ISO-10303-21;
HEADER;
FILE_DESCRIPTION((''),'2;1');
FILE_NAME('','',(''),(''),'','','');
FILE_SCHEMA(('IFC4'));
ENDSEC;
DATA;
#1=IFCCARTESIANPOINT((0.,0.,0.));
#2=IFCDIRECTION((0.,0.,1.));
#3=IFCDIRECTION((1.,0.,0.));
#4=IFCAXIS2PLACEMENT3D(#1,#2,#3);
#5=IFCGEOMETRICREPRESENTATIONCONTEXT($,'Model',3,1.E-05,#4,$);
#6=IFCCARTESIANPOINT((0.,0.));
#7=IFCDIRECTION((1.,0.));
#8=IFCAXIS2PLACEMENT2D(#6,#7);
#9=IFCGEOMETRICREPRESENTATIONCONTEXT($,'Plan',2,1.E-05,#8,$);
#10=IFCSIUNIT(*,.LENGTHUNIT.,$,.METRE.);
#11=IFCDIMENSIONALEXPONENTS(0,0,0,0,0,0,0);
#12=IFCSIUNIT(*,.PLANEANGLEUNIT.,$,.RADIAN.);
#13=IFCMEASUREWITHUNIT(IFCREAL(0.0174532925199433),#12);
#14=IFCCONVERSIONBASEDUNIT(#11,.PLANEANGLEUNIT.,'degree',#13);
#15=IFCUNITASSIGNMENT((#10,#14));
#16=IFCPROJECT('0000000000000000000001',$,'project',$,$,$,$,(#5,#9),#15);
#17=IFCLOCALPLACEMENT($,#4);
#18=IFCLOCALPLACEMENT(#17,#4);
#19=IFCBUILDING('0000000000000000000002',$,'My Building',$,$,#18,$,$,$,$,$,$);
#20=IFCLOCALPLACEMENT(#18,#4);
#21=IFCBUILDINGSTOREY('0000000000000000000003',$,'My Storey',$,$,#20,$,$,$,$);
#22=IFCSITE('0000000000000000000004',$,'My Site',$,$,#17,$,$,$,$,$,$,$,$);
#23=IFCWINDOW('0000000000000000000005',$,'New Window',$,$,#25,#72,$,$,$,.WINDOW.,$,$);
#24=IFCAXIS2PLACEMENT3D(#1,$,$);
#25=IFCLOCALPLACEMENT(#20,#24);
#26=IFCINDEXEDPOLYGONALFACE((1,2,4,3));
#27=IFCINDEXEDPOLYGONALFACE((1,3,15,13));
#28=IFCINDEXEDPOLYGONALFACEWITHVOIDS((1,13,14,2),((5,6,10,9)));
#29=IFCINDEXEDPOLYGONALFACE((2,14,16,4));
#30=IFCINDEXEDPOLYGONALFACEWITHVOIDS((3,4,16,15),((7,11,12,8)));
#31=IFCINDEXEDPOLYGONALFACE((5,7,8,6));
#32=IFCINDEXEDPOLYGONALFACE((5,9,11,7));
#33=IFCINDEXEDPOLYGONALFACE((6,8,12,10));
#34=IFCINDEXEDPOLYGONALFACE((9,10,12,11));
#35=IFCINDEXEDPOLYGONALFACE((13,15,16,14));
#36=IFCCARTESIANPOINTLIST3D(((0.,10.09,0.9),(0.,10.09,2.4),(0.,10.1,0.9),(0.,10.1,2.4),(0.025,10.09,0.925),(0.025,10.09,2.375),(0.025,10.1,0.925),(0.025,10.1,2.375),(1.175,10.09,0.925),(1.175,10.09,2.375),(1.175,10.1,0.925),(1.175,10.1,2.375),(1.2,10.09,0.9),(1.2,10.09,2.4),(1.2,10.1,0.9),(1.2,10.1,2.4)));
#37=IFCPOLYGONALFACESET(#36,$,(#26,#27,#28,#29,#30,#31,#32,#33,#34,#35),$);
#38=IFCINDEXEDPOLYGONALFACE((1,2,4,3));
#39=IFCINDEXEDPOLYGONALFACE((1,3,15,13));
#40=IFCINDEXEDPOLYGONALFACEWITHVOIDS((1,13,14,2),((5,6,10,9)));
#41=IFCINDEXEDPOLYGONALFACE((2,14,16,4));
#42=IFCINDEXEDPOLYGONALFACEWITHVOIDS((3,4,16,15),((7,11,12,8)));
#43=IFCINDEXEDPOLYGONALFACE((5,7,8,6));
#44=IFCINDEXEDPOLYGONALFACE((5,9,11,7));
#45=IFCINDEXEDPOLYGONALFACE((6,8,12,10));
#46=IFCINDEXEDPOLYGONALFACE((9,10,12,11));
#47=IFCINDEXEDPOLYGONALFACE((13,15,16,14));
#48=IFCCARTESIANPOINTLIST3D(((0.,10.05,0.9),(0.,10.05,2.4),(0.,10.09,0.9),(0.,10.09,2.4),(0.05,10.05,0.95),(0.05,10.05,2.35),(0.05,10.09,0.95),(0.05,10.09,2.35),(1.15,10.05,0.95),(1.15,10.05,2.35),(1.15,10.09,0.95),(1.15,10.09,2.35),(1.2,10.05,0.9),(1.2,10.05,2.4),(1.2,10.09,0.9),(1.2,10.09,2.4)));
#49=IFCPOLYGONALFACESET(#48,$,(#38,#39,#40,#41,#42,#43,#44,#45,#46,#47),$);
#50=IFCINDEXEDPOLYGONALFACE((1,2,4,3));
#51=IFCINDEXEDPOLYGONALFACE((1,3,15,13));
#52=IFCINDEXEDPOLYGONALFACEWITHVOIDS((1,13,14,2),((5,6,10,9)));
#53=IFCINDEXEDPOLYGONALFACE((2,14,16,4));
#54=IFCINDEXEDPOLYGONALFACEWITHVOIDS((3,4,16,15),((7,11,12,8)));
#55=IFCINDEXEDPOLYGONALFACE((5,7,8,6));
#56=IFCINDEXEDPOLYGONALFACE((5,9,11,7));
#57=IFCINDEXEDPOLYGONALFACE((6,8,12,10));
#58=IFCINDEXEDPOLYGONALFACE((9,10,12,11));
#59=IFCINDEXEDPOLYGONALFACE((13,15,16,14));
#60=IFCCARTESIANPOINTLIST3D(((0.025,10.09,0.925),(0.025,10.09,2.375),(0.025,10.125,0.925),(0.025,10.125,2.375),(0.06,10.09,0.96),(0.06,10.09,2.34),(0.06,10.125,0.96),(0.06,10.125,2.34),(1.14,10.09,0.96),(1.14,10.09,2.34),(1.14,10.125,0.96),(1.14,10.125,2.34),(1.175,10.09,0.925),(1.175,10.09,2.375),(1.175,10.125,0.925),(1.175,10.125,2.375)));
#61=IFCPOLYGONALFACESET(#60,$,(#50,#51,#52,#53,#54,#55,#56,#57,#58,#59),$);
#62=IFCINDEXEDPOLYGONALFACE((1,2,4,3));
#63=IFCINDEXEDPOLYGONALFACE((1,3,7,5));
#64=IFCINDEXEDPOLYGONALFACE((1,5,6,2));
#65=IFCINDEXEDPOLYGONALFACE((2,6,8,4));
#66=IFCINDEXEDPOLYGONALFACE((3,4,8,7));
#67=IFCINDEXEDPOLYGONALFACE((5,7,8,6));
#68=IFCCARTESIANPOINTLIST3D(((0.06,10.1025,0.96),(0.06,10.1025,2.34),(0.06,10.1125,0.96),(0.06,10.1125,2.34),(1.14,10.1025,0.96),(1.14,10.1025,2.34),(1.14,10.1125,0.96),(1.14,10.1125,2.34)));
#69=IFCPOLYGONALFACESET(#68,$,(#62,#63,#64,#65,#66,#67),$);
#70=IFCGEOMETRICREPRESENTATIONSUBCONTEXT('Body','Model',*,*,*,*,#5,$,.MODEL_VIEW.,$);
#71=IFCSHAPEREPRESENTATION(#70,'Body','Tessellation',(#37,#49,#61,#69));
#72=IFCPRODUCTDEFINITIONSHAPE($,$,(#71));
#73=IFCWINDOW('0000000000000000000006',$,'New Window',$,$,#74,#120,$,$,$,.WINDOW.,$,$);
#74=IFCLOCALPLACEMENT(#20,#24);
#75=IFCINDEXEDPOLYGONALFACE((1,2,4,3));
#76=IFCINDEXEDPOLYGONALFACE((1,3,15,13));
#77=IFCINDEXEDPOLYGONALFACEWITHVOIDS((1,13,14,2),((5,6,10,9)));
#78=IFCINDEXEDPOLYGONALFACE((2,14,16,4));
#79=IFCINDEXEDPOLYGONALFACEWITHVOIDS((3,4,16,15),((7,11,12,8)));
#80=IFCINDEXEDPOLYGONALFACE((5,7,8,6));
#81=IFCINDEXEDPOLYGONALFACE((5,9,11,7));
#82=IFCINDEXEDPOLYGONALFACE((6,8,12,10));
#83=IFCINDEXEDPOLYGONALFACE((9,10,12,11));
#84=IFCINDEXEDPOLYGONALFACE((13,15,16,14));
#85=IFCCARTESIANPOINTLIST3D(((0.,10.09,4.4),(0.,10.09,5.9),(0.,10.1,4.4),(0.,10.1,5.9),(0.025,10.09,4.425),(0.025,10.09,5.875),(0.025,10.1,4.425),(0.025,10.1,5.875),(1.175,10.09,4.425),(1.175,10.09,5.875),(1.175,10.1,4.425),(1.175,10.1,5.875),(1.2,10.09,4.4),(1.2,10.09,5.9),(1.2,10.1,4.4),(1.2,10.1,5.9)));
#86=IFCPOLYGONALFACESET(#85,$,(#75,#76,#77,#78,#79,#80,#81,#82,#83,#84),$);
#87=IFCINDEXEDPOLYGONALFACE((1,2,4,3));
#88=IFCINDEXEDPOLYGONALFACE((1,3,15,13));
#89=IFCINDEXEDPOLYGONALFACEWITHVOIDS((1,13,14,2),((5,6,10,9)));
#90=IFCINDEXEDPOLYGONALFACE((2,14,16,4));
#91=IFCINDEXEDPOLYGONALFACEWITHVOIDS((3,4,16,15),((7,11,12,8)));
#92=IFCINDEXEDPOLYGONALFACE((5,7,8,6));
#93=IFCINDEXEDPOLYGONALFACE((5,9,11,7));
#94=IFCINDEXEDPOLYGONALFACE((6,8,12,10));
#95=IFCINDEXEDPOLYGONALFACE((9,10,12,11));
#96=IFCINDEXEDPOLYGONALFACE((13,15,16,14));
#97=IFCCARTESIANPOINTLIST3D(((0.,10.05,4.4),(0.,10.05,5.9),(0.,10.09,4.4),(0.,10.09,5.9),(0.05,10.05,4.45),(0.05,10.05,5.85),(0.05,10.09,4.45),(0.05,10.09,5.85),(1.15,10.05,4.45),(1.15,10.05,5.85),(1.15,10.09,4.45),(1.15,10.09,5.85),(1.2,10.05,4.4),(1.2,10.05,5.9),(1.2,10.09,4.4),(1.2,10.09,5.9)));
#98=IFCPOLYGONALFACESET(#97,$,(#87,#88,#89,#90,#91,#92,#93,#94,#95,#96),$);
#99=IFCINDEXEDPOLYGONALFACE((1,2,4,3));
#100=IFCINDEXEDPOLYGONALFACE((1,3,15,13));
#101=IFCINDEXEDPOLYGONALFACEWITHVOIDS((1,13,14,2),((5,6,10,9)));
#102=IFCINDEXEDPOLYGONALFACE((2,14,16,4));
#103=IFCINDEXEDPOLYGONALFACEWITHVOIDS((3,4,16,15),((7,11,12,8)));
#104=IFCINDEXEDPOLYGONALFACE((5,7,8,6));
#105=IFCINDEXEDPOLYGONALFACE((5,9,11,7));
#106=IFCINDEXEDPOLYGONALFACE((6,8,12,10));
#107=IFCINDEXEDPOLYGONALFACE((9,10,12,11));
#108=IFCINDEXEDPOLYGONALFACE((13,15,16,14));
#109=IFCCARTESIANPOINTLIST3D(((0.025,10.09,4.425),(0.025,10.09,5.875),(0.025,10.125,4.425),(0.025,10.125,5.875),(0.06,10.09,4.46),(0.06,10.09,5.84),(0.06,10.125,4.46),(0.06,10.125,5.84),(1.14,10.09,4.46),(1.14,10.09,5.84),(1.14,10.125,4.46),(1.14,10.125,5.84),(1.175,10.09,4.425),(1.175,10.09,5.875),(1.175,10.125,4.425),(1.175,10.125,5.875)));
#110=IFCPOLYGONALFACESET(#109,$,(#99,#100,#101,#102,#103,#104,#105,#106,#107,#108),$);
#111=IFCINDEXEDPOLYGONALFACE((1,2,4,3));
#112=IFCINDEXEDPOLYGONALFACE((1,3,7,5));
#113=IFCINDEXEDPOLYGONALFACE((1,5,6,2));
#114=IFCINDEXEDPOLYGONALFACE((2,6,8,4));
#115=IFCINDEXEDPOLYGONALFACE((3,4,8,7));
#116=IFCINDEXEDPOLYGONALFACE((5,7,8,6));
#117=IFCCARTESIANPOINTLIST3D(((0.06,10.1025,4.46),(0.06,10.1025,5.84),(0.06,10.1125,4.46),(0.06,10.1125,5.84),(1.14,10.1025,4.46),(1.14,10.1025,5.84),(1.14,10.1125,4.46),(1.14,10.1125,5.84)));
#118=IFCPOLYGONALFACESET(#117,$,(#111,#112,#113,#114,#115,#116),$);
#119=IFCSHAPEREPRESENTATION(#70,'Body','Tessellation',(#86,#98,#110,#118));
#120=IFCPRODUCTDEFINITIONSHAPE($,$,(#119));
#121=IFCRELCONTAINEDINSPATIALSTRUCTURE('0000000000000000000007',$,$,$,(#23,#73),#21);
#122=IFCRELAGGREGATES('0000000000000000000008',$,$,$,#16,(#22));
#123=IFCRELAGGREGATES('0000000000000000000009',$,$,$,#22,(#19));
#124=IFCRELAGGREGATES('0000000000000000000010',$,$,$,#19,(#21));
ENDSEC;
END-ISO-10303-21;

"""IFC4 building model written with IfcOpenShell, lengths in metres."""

from ifc_helpers import new_model, entity, si_unit, converted_unit, frame, origin_with_axes, origin_2d_with_axis, place, context, subcontext, project, spatial, line, indexed_curve, outline, extrude, element, save


model = new_model("IFC4")

# Units and contexts
model_context = context("Model", 3, precision=1e-05, world=origin_with_axes())
plan_context = context("Plan", 2, precision=1e-05, world=origin_2d_with_axis())
body_context = subcontext(model_context, "Body", "Model", "MODEL_VIEW")
ifc_project = project(units=[si_unit("LENGTHUNIT", "METRE"), converted_unit("PLANEANGLEUNIT", "degree", entity("IfcReal", 0.0174532925199433), si_unit("PLANEANGLEUNIT", "RADIAN"), dimensions=[0, 0, 0, 0, 0, 0, 0])], contexts=[model_context, plan_context])

# Site, building, storey
site_placement = place(None, origin_with_axes())
site = spatial("IfcSite", under=ifc_project, at=site_placement, Name="My Site")
building_placement = place(site_placement, origin_with_axes())
building = spatial("IfcBuilding", under=site, at=building_placement, Name="My Building")
storey_placement = place(building_placement, origin_with_axes())
storey = spatial("IfcBuildingStorey", under=building, at=storey_placement, Name="My Storey")

# Windows
for number, where, z_axis, x_axis, name in (
    (1, (0.0, 10.0, 0.9), (0.0, 0.0, 1.0), (1.0, 0.0, 0.0), "New Window"),
    (2, (0.0, 10.0, 4.4), (0.0, 0.0, 1.0), (1.0, 0.0, 0.0), "New Window"),
):
    element("IfcWindow", number, at=place(storey_placement, frame(where, z_axis=z_axis, x_axis=x_axis)), inside=storey, Name=name, PredefinedType="WINDOW", context=body_context, shape_type="SweptSolid", body=[
        extrude(outline(indexed_curve([(0.0, 0.0), (1.2, 0.0), (1.2, 1.5), (0.0, 1.5)], segments=[line(1, 2, 3, 4, 1)]), holes=[indexed_curve([(0.025, 0.025), (1.175, 0.025), (1.175, 1.475), (0.025, 1.475)], segments=[line(1, 2, 3, 4, 1)])]), frame((0.0, 0.09, 0.0), z_axis=(0.0, -1.0, 0.0), x_axis=(1.0, 0.0, 0.0)), (0.0, 0.0, -1.0), 0.01),
        extrude(outline(indexed_curve([(0.0, 0.0), (1.2, 0.0), (1.2, 1.5), (0.0, 1.5)], segments=[line(1, 2, 3, 4, 1)]), holes=[indexed_curve([(0.05, 0.05), (1.15, 0.05), (1.15, 1.45), (0.05, 1.45)], segments=[line(1, 2, 3, 4, 1)])]), frame((0.0, 0.05, 0.0), z_axis=(0.0, -1.0, 0.0), x_axis=(1.0, 0.0, 0.0)), (0.0, 0.0, -1.0), 0.04),
        extrude(outline(indexed_curve([(0.0, 0.0), (1.15, 0.0), (1.15, 1.45), (0.0, 1.45)], segments=[line(1, 2, 3, 4, 1)]), holes=[indexed_curve([(0.035, 0.035), (1.115, 0.035), (1.115, 1.415), (0.035, 1.415)], segments=[line(1, 2, 3, 4, 1)])]), frame((0.025, 0.09, 0.025), z_axis=(0.0, -1.0, 0.0), x_axis=(1.0, 0.0, 0.0)), (0.0, 0.0, -1.0), 0.035),
        extrude(outline(indexed_curve([(0.035, 0.035), (1.115, 0.035), (1.115, 1.415), (0.035, 1.415)], segments=[line(1, 2, 3, 4, 1)])), frame((0.025, 0.1025, 0.025), z_axis=(0.0, -1.0, 0.0), x_axis=(1.0, 0.0, 0.0)), (0.0, 0.0, -1.0), 0.01),
    ])

save(model, "model.ifc")
